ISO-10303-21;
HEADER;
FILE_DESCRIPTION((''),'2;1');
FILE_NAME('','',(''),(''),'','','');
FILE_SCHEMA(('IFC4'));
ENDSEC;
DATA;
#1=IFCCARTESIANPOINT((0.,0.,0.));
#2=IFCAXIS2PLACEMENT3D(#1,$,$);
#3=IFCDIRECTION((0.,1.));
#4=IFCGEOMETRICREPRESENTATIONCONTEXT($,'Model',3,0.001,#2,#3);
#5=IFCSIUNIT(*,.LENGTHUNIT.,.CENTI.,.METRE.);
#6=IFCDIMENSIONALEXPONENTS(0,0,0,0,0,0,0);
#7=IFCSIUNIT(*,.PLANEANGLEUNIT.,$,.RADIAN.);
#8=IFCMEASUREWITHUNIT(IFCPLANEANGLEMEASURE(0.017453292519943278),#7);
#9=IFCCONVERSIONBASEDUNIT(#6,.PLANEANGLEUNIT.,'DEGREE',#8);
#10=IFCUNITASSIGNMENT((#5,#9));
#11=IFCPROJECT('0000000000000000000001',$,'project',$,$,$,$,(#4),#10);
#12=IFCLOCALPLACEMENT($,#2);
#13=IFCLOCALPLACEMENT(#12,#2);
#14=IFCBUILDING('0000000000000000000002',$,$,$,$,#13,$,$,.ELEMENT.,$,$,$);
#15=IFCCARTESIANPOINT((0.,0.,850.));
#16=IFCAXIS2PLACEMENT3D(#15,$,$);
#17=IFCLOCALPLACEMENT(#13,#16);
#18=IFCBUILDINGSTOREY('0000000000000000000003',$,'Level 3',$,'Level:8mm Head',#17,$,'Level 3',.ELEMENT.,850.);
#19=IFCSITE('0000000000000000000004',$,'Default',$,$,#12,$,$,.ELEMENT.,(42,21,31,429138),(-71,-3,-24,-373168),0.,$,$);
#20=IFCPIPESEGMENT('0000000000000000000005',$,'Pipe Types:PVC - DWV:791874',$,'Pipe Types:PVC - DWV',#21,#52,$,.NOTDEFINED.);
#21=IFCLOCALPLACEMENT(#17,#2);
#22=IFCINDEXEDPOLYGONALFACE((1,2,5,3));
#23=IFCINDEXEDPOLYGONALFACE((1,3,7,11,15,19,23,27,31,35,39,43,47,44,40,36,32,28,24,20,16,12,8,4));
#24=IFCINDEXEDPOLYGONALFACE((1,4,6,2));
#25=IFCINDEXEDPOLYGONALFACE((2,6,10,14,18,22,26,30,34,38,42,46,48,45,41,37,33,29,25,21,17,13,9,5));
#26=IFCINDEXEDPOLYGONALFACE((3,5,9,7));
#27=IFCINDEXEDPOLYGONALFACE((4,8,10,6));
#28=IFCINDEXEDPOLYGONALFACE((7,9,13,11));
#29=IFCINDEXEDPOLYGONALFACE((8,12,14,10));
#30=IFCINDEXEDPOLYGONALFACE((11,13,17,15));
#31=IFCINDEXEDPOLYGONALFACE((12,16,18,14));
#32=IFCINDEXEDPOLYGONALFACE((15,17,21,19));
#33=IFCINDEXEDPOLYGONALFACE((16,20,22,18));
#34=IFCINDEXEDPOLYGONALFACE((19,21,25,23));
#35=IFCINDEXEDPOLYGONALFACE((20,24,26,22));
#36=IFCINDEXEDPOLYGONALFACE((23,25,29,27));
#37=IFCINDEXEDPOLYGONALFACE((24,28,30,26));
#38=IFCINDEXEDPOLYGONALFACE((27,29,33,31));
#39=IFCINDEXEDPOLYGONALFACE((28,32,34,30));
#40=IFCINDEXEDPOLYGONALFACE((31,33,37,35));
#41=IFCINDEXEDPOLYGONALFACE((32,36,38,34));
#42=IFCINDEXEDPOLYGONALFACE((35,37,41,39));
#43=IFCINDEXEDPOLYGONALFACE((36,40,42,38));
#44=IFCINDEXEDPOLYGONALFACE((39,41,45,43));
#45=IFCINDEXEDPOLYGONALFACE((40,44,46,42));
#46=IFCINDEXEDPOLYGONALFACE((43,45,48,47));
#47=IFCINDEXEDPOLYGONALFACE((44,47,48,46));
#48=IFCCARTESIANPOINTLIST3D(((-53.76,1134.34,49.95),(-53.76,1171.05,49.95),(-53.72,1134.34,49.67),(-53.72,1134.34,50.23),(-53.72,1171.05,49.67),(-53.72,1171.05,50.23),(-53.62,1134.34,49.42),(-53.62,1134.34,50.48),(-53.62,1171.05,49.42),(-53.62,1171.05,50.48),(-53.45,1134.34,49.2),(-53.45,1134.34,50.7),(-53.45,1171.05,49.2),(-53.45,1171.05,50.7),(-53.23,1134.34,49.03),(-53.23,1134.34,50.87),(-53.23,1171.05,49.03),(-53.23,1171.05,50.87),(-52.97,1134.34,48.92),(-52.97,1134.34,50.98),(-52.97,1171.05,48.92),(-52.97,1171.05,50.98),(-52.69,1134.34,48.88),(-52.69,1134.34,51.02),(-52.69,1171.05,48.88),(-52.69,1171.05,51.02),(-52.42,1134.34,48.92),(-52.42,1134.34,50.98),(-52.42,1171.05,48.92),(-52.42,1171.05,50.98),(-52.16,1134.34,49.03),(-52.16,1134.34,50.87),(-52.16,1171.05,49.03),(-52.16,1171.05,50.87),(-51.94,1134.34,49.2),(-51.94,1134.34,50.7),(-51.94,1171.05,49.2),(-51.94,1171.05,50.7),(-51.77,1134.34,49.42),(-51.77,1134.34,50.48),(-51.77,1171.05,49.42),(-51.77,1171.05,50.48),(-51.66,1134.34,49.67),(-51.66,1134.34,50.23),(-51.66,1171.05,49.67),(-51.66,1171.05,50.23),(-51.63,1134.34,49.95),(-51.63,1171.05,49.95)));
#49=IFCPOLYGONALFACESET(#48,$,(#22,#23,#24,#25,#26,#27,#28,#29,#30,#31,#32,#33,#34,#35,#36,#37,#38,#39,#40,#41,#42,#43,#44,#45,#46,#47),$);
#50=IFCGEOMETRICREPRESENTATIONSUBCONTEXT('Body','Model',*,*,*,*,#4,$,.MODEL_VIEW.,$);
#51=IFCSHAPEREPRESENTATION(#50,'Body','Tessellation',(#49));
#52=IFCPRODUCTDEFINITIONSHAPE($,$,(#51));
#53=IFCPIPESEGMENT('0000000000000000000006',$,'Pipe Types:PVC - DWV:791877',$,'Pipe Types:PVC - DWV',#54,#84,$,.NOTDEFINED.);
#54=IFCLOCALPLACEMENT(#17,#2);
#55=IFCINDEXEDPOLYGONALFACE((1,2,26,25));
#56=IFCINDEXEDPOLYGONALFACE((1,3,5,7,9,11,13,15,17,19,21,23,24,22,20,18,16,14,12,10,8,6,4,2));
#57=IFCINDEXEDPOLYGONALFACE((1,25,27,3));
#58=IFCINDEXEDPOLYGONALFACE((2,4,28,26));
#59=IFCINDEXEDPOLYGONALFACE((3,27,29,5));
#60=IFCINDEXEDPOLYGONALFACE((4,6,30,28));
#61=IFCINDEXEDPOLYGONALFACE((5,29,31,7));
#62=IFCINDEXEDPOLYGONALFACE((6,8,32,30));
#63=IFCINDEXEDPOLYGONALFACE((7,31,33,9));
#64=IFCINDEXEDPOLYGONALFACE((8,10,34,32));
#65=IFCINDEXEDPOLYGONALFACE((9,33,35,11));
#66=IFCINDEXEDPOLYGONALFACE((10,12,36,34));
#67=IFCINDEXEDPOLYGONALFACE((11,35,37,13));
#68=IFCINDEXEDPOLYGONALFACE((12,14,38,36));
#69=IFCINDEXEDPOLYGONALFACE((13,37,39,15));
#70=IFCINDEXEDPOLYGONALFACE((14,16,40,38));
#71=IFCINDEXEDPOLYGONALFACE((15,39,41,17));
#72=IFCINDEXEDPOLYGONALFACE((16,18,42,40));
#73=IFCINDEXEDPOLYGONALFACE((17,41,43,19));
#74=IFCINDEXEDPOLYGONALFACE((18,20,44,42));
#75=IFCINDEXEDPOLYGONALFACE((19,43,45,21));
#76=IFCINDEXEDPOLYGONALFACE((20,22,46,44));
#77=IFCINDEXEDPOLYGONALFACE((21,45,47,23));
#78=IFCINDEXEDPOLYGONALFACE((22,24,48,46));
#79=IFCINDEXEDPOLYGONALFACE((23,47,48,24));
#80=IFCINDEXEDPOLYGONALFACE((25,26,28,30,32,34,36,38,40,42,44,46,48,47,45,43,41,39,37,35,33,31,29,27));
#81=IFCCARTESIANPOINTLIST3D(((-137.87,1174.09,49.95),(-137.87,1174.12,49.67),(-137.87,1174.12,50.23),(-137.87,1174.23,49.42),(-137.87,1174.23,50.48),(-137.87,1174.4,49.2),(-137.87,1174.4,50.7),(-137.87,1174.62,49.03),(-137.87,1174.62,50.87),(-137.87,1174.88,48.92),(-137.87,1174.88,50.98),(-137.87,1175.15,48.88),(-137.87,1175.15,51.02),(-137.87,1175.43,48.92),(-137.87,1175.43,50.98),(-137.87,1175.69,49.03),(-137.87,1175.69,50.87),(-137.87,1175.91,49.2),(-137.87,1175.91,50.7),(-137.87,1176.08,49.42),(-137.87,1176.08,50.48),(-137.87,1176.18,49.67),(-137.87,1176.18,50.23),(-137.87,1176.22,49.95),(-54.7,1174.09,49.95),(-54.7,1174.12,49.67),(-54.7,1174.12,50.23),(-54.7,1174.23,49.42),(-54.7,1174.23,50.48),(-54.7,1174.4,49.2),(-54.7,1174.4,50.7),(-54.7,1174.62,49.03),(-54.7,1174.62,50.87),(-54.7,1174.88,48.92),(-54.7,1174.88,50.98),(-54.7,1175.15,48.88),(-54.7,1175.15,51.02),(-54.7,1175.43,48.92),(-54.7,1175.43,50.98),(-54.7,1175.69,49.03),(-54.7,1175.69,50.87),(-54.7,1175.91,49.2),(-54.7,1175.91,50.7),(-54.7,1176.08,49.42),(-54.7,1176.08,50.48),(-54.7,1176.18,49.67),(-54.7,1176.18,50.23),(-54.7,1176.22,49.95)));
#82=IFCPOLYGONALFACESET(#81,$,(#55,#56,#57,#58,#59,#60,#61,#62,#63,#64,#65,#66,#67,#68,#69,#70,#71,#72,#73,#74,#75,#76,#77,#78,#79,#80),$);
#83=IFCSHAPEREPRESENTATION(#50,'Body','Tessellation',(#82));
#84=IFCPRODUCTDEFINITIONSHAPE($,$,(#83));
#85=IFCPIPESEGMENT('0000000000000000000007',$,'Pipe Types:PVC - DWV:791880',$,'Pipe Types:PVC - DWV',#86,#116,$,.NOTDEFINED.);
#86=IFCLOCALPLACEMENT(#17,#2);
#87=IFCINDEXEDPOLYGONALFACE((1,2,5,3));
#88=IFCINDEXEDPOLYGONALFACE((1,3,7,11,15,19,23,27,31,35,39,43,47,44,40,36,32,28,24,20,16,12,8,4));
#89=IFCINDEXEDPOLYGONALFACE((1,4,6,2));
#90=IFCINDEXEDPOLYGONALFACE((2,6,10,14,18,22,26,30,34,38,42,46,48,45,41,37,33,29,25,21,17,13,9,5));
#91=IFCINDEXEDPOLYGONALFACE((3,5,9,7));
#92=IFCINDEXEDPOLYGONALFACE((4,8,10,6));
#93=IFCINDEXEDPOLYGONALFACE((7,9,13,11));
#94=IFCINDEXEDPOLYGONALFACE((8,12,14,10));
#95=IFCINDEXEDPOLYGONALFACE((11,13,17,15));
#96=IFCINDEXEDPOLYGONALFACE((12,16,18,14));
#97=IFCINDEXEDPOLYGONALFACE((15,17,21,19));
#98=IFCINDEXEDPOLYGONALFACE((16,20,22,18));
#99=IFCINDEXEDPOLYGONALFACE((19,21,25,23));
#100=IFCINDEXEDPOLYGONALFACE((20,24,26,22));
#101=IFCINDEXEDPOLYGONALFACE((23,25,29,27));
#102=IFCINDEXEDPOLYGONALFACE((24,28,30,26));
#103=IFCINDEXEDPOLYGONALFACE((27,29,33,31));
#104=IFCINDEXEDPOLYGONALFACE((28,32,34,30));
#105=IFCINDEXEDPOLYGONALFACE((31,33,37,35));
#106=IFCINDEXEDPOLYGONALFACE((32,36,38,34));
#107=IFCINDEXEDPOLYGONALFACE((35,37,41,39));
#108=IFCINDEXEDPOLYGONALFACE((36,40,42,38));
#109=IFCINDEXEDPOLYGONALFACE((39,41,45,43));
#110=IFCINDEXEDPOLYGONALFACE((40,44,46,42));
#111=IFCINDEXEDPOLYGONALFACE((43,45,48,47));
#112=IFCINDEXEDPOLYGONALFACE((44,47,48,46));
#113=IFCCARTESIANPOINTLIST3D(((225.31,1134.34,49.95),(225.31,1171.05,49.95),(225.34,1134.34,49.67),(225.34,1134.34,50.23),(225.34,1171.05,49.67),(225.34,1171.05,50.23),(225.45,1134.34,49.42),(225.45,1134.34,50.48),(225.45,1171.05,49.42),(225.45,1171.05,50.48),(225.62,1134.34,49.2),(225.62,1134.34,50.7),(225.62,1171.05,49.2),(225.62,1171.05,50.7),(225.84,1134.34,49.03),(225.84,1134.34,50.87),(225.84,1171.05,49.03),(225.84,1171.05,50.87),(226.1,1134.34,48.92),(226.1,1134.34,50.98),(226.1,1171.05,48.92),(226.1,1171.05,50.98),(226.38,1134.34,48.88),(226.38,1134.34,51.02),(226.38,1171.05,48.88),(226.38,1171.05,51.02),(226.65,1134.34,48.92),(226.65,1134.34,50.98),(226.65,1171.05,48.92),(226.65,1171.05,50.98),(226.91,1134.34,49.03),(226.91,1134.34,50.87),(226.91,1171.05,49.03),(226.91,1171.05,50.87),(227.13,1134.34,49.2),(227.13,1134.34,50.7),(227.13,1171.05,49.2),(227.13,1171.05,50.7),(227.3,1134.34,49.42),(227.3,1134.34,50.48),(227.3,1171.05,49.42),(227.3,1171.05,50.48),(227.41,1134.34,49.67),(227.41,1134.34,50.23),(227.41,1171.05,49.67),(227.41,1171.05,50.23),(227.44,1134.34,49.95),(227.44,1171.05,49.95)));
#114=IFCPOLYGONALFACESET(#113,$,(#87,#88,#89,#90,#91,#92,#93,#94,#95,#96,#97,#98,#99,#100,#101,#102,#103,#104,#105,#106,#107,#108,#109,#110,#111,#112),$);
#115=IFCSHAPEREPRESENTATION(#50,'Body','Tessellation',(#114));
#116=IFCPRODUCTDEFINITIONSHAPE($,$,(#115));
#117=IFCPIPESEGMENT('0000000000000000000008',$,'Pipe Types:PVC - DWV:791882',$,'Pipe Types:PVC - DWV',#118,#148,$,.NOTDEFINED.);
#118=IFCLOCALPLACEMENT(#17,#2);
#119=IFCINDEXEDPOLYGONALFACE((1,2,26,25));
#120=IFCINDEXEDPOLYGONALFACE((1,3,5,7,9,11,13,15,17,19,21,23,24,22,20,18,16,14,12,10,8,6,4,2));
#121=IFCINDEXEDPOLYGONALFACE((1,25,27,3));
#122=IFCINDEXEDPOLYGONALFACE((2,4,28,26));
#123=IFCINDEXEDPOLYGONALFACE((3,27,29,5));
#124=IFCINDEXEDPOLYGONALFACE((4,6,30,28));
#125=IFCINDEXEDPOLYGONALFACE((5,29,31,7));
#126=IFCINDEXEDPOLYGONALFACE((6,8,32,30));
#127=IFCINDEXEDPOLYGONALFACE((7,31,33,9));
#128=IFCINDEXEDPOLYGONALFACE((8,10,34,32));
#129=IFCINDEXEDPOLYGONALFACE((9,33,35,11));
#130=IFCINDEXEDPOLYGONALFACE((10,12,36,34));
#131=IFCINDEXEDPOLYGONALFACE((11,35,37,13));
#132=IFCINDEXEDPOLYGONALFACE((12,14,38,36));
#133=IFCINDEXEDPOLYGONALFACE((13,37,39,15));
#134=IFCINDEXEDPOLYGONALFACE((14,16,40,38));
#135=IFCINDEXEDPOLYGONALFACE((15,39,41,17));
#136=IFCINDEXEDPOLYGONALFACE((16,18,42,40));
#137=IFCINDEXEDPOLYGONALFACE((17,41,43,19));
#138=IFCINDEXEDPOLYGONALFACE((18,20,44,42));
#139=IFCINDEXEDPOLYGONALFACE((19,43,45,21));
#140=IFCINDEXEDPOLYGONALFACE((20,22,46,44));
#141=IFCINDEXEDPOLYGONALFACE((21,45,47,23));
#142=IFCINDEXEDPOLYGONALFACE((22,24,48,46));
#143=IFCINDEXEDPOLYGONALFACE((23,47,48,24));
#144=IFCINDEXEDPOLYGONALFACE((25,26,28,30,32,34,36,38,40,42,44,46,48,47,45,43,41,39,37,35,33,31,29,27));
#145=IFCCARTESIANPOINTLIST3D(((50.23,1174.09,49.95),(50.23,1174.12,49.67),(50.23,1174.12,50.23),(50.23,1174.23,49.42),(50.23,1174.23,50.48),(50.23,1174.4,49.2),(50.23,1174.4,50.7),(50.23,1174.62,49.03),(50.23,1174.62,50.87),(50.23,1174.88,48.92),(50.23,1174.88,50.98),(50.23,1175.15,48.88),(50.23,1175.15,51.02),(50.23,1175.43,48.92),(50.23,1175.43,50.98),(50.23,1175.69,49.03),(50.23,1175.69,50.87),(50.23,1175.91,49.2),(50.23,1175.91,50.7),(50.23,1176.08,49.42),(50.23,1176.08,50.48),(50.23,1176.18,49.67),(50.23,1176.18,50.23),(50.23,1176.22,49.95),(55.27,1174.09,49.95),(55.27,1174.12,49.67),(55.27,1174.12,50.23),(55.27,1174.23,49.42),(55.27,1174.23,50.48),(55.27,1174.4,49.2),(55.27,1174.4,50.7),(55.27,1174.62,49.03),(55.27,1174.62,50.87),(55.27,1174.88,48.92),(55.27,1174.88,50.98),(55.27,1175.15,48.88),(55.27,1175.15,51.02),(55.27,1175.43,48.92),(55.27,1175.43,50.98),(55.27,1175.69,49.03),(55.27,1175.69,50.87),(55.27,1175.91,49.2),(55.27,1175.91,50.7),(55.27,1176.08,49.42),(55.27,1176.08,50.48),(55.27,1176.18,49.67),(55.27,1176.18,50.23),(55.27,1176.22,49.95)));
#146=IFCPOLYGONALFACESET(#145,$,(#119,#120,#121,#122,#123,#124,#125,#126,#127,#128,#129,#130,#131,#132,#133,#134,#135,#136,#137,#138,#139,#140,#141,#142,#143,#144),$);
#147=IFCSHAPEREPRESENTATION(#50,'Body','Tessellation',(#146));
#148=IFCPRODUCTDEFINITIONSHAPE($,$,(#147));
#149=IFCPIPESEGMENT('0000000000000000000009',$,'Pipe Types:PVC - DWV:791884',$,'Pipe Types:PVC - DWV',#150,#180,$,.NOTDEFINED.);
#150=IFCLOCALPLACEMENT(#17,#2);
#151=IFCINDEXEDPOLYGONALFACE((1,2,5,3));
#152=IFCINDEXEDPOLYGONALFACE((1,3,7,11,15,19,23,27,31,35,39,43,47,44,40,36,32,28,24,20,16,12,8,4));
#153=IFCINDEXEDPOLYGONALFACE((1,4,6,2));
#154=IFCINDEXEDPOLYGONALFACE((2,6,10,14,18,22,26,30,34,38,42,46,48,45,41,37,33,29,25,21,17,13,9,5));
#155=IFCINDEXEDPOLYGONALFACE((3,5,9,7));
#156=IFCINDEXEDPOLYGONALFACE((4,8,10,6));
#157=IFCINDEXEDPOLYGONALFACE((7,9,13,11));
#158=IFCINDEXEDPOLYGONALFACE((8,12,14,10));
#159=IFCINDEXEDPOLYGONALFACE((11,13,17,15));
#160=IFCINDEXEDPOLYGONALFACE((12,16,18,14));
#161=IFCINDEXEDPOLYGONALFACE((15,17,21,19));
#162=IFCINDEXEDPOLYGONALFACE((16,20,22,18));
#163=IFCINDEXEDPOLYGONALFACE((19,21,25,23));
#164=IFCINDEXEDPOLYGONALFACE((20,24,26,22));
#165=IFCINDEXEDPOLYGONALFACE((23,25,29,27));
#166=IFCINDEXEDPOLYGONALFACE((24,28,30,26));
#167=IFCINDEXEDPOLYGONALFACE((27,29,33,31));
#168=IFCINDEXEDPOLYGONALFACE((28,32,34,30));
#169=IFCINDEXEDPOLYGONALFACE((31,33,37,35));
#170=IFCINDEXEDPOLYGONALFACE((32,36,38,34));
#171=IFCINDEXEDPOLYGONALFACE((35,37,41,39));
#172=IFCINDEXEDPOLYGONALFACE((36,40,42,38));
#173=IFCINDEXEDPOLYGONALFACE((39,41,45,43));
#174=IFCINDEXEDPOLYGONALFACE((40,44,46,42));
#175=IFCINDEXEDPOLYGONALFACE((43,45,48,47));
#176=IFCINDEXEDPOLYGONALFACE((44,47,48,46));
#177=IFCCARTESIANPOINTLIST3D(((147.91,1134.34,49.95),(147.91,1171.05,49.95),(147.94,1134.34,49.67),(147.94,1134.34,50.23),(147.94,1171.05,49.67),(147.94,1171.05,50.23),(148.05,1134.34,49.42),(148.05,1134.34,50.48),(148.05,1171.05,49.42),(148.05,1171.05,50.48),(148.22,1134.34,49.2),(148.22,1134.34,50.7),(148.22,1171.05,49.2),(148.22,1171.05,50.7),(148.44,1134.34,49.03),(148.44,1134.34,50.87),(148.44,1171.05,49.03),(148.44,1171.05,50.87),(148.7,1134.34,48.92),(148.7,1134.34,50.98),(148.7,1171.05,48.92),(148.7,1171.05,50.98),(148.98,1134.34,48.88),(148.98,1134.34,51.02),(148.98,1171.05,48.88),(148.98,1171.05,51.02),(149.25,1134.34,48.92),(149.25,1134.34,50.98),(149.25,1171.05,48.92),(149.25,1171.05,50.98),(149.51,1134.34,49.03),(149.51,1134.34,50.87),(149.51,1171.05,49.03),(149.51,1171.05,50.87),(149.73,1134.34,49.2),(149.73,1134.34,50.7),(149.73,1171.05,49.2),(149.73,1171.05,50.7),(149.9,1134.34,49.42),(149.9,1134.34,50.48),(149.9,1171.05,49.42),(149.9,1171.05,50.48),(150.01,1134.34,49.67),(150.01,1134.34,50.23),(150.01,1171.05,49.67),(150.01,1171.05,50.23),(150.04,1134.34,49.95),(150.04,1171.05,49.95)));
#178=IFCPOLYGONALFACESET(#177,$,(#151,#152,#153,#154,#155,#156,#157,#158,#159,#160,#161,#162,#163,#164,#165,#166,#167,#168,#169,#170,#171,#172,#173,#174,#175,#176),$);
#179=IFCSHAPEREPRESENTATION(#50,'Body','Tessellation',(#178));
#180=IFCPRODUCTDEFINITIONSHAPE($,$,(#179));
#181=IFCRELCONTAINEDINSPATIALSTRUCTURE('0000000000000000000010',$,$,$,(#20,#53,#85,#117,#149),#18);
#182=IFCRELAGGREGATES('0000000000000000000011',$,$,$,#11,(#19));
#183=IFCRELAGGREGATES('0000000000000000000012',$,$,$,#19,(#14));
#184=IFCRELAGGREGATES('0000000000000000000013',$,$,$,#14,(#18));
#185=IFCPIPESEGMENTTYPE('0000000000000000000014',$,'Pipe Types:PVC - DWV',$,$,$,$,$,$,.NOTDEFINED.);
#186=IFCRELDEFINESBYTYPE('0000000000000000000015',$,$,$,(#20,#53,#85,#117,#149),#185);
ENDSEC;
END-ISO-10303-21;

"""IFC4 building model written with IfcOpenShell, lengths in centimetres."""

from ifc_helpers import new_model, entity, si_unit, converted_unit, direction, frame, origin, place, context, subcontext, project, spatial, arc, indexed_curve, outline, extrude, type_object, element, save


model = new_model("IFC4")

# Units and contexts
model_context = context("Model", 3, precision=0.001, world=origin(), true_north=direction((0.0, 1.0)))
body_context = subcontext(model_context, "Body", "Model", "MODEL_VIEW")
ifc_project = project(units=[si_unit("LENGTHUNIT", "METRE", prefix="CENTI"), converted_unit("PLANEANGLEUNIT", "DEGREE", entity("IfcPlaneAngleMeasure", 0.017453292519943278), si_unit("PLANEANGLEUNIT", "RADIAN"), dimensions=[0, 0, 0, 0, 0, 0, 0])], contexts=[model_context])

# Site, building, storey
site_placement = place(None, origin())
site = spatial("IfcSite", under=ifc_project, at=site_placement, Name="Default", CompositionType="ELEMENT", RefLatitude=(42, 21, 31, 429138), RefLongitude=(-71, -3, -24, -373168), RefElevation=0.0)
building_placement = place(site_placement, origin())
building = spatial("IfcBuilding", under=site, at=building_placement, CompositionType="ELEMENT")
storey_placement = place(building_placement, frame((0.0, 0.0, 850.0)))
storey = spatial("IfcBuildingStorey", under=building, at=storey_placement, Name="Level 3", ObjectType="Level:8mm Head", LongName="Level 3", CompositionType="ELEMENT", Elevation=850.0)

# Pipe segments
pipe_segment_type = type_object("IfcPipeSegmentType", Name="Pipe Types:PVC - DWV", PredefinedType="NOTDEFINED")
pipe_segment_1_placement = place(storey_placement, origin())
element("IfcPipeSegment", 1, at=pipe_segment_1_placement, inside=storey, type_object=pipe_segment_type, Name="Pipe Types:PVC - DWV:791874", ObjectType="Pipe Types:PVC - DWV", PredefinedType="NOTDEFINED", context=body_context, shape_type="SweptSolid", body=[
    extrude(outline(indexed_curve([(1.07, 0.0), (0.75, 0.75), (0.0, 1.07), (-0.75, 0.75), (-1.07, 0.0), (-0.75, -0.75), (0.0, -1.07), (0.75, -0.75)], segments=[arc(1, 2, 3), arc(3, 4, 5), arc(5, 6, 7), arc(7, 8, 1)], self_intersect=False)), frame((-52.69, 1134.34, 49.95), z_axis=(0.0, 1.0, 0.0), x_axis=(-1.0, 0.0, 0.0)), (0.0, 0.0, 1.0), 36.71),
])
pipe_segment_2_placement = place(storey_placement, origin())
element("IfcPipeSegment", 2, at=pipe_segment_2_placement, inside=storey, type_object=pipe_segment_type, Name="Pipe Types:PVC - DWV:791877", ObjectType="Pipe Types:PVC - DWV", PredefinedType="NOTDEFINED", context=body_context, shape_type="SweptSolid", body=[
    extrude(outline(indexed_curve([(1.07, 0.0), (0.75, 0.75), (0.0, 1.07), (-0.75, 0.75), (-1.07, 0.0), (-0.75, -0.75), (0.0, -1.07), (0.75, -0.75)], segments=[arc(1, 2, 3), arc(3, 4, 5), arc(5, 6, 7), arc(7, 8, 1)], self_intersect=False)), frame((-137.87, 1175.15, 49.95), z_axis=(1.0, 0.0, 0.0), x_axis=(0.0, -1.0, 0.0)), (0.0, 0.0, 1.0), 83.17),
])
pipe_segment_3_placement = place(storey_placement, origin())
element("IfcPipeSegment", 3, at=pipe_segment_3_placement, inside=storey, type_object=pipe_segment_type, Name="Pipe Types:PVC - DWV:791880", ObjectType="Pipe Types:PVC - DWV", PredefinedType="NOTDEFINED", context=body_context, shape_type="SweptSolid", body=[
    extrude(outline(indexed_curve([(1.07, 0.0), (0.75, 0.75), (0.0, 1.07), (-0.75, 0.75), (-1.07, 0.0), (-0.75, -0.75), (0.0, -1.07), (0.75, -0.75)], segments=[arc(1, 2, 3), arc(3, 4, 5), arc(5, 6, 7), arc(7, 8, 1)], self_intersect=False)), frame((226.38, 1134.34, 49.95), z_axis=(0.0, 1.0, 0.0), x_axis=(-1.0, 0.0, 0.0)), (0.0, 0.0, 1.0), 36.71),
])
pipe_segment_4_placement = place(storey_placement, origin())
element("IfcPipeSegment", 4, at=pipe_segment_4_placement, inside=storey, type_object=pipe_segment_type, Name="Pipe Types:PVC - DWV:791882", ObjectType="Pipe Types:PVC - DWV", PredefinedType="NOTDEFINED", context=body_context, shape_type="SweptSolid", body=[
    extrude(outline(indexed_curve([(1.07, 0.0), (0.75, 0.75), (0.0, 1.07), (-0.75, 0.75), (-1.07, 0.0), (-0.75, -0.75), (0.0, -1.07), (0.75, -0.75)], segments=[arc(1, 2, 3), arc(3, 4, 5), arc(5, 6, 7), arc(7, 8, 1)], self_intersect=False)), frame((50.23, 1175.15, 49.95), z_axis=(1.0, 0.0, 0.0), x_axis=(0.0, 1.0, 0.0)), (0.0, 0.0, 1.0), 5.04),
])
pipe_segment_5_placement = place(storey_placement, origin())
element("IfcPipeSegment", 5, at=pipe_segment_5_placement, inside=storey, type_object=pipe_segment_type, Name="Pipe Types:PVC - DWV:791884", ObjectType="Pipe Types:PVC - DWV", PredefinedType="NOTDEFINED", context=body_context, shape_type="SweptSolid", body=[
    extrude(outline(indexed_curve([(1.07, 0.0), (0.75, 0.75), (0.0, 1.07), (-0.75, 0.75), (-1.07, 0.0), (-0.75, -0.75), (0.0, -1.07), (0.75, -0.75)], segments=[arc(1, 2, 3), arc(3, 4, 5), arc(5, 6, 7), arc(7, 8, 1)], self_intersect=False)), frame((148.98, 1134.34, 49.95), z_axis=(0.0, 1.0, 0.0), x_axis=(-1.0, 0.0, 0.0)), (0.0, 0.0, 1.0), 36.71),
])

save(model, "model.ifc")
